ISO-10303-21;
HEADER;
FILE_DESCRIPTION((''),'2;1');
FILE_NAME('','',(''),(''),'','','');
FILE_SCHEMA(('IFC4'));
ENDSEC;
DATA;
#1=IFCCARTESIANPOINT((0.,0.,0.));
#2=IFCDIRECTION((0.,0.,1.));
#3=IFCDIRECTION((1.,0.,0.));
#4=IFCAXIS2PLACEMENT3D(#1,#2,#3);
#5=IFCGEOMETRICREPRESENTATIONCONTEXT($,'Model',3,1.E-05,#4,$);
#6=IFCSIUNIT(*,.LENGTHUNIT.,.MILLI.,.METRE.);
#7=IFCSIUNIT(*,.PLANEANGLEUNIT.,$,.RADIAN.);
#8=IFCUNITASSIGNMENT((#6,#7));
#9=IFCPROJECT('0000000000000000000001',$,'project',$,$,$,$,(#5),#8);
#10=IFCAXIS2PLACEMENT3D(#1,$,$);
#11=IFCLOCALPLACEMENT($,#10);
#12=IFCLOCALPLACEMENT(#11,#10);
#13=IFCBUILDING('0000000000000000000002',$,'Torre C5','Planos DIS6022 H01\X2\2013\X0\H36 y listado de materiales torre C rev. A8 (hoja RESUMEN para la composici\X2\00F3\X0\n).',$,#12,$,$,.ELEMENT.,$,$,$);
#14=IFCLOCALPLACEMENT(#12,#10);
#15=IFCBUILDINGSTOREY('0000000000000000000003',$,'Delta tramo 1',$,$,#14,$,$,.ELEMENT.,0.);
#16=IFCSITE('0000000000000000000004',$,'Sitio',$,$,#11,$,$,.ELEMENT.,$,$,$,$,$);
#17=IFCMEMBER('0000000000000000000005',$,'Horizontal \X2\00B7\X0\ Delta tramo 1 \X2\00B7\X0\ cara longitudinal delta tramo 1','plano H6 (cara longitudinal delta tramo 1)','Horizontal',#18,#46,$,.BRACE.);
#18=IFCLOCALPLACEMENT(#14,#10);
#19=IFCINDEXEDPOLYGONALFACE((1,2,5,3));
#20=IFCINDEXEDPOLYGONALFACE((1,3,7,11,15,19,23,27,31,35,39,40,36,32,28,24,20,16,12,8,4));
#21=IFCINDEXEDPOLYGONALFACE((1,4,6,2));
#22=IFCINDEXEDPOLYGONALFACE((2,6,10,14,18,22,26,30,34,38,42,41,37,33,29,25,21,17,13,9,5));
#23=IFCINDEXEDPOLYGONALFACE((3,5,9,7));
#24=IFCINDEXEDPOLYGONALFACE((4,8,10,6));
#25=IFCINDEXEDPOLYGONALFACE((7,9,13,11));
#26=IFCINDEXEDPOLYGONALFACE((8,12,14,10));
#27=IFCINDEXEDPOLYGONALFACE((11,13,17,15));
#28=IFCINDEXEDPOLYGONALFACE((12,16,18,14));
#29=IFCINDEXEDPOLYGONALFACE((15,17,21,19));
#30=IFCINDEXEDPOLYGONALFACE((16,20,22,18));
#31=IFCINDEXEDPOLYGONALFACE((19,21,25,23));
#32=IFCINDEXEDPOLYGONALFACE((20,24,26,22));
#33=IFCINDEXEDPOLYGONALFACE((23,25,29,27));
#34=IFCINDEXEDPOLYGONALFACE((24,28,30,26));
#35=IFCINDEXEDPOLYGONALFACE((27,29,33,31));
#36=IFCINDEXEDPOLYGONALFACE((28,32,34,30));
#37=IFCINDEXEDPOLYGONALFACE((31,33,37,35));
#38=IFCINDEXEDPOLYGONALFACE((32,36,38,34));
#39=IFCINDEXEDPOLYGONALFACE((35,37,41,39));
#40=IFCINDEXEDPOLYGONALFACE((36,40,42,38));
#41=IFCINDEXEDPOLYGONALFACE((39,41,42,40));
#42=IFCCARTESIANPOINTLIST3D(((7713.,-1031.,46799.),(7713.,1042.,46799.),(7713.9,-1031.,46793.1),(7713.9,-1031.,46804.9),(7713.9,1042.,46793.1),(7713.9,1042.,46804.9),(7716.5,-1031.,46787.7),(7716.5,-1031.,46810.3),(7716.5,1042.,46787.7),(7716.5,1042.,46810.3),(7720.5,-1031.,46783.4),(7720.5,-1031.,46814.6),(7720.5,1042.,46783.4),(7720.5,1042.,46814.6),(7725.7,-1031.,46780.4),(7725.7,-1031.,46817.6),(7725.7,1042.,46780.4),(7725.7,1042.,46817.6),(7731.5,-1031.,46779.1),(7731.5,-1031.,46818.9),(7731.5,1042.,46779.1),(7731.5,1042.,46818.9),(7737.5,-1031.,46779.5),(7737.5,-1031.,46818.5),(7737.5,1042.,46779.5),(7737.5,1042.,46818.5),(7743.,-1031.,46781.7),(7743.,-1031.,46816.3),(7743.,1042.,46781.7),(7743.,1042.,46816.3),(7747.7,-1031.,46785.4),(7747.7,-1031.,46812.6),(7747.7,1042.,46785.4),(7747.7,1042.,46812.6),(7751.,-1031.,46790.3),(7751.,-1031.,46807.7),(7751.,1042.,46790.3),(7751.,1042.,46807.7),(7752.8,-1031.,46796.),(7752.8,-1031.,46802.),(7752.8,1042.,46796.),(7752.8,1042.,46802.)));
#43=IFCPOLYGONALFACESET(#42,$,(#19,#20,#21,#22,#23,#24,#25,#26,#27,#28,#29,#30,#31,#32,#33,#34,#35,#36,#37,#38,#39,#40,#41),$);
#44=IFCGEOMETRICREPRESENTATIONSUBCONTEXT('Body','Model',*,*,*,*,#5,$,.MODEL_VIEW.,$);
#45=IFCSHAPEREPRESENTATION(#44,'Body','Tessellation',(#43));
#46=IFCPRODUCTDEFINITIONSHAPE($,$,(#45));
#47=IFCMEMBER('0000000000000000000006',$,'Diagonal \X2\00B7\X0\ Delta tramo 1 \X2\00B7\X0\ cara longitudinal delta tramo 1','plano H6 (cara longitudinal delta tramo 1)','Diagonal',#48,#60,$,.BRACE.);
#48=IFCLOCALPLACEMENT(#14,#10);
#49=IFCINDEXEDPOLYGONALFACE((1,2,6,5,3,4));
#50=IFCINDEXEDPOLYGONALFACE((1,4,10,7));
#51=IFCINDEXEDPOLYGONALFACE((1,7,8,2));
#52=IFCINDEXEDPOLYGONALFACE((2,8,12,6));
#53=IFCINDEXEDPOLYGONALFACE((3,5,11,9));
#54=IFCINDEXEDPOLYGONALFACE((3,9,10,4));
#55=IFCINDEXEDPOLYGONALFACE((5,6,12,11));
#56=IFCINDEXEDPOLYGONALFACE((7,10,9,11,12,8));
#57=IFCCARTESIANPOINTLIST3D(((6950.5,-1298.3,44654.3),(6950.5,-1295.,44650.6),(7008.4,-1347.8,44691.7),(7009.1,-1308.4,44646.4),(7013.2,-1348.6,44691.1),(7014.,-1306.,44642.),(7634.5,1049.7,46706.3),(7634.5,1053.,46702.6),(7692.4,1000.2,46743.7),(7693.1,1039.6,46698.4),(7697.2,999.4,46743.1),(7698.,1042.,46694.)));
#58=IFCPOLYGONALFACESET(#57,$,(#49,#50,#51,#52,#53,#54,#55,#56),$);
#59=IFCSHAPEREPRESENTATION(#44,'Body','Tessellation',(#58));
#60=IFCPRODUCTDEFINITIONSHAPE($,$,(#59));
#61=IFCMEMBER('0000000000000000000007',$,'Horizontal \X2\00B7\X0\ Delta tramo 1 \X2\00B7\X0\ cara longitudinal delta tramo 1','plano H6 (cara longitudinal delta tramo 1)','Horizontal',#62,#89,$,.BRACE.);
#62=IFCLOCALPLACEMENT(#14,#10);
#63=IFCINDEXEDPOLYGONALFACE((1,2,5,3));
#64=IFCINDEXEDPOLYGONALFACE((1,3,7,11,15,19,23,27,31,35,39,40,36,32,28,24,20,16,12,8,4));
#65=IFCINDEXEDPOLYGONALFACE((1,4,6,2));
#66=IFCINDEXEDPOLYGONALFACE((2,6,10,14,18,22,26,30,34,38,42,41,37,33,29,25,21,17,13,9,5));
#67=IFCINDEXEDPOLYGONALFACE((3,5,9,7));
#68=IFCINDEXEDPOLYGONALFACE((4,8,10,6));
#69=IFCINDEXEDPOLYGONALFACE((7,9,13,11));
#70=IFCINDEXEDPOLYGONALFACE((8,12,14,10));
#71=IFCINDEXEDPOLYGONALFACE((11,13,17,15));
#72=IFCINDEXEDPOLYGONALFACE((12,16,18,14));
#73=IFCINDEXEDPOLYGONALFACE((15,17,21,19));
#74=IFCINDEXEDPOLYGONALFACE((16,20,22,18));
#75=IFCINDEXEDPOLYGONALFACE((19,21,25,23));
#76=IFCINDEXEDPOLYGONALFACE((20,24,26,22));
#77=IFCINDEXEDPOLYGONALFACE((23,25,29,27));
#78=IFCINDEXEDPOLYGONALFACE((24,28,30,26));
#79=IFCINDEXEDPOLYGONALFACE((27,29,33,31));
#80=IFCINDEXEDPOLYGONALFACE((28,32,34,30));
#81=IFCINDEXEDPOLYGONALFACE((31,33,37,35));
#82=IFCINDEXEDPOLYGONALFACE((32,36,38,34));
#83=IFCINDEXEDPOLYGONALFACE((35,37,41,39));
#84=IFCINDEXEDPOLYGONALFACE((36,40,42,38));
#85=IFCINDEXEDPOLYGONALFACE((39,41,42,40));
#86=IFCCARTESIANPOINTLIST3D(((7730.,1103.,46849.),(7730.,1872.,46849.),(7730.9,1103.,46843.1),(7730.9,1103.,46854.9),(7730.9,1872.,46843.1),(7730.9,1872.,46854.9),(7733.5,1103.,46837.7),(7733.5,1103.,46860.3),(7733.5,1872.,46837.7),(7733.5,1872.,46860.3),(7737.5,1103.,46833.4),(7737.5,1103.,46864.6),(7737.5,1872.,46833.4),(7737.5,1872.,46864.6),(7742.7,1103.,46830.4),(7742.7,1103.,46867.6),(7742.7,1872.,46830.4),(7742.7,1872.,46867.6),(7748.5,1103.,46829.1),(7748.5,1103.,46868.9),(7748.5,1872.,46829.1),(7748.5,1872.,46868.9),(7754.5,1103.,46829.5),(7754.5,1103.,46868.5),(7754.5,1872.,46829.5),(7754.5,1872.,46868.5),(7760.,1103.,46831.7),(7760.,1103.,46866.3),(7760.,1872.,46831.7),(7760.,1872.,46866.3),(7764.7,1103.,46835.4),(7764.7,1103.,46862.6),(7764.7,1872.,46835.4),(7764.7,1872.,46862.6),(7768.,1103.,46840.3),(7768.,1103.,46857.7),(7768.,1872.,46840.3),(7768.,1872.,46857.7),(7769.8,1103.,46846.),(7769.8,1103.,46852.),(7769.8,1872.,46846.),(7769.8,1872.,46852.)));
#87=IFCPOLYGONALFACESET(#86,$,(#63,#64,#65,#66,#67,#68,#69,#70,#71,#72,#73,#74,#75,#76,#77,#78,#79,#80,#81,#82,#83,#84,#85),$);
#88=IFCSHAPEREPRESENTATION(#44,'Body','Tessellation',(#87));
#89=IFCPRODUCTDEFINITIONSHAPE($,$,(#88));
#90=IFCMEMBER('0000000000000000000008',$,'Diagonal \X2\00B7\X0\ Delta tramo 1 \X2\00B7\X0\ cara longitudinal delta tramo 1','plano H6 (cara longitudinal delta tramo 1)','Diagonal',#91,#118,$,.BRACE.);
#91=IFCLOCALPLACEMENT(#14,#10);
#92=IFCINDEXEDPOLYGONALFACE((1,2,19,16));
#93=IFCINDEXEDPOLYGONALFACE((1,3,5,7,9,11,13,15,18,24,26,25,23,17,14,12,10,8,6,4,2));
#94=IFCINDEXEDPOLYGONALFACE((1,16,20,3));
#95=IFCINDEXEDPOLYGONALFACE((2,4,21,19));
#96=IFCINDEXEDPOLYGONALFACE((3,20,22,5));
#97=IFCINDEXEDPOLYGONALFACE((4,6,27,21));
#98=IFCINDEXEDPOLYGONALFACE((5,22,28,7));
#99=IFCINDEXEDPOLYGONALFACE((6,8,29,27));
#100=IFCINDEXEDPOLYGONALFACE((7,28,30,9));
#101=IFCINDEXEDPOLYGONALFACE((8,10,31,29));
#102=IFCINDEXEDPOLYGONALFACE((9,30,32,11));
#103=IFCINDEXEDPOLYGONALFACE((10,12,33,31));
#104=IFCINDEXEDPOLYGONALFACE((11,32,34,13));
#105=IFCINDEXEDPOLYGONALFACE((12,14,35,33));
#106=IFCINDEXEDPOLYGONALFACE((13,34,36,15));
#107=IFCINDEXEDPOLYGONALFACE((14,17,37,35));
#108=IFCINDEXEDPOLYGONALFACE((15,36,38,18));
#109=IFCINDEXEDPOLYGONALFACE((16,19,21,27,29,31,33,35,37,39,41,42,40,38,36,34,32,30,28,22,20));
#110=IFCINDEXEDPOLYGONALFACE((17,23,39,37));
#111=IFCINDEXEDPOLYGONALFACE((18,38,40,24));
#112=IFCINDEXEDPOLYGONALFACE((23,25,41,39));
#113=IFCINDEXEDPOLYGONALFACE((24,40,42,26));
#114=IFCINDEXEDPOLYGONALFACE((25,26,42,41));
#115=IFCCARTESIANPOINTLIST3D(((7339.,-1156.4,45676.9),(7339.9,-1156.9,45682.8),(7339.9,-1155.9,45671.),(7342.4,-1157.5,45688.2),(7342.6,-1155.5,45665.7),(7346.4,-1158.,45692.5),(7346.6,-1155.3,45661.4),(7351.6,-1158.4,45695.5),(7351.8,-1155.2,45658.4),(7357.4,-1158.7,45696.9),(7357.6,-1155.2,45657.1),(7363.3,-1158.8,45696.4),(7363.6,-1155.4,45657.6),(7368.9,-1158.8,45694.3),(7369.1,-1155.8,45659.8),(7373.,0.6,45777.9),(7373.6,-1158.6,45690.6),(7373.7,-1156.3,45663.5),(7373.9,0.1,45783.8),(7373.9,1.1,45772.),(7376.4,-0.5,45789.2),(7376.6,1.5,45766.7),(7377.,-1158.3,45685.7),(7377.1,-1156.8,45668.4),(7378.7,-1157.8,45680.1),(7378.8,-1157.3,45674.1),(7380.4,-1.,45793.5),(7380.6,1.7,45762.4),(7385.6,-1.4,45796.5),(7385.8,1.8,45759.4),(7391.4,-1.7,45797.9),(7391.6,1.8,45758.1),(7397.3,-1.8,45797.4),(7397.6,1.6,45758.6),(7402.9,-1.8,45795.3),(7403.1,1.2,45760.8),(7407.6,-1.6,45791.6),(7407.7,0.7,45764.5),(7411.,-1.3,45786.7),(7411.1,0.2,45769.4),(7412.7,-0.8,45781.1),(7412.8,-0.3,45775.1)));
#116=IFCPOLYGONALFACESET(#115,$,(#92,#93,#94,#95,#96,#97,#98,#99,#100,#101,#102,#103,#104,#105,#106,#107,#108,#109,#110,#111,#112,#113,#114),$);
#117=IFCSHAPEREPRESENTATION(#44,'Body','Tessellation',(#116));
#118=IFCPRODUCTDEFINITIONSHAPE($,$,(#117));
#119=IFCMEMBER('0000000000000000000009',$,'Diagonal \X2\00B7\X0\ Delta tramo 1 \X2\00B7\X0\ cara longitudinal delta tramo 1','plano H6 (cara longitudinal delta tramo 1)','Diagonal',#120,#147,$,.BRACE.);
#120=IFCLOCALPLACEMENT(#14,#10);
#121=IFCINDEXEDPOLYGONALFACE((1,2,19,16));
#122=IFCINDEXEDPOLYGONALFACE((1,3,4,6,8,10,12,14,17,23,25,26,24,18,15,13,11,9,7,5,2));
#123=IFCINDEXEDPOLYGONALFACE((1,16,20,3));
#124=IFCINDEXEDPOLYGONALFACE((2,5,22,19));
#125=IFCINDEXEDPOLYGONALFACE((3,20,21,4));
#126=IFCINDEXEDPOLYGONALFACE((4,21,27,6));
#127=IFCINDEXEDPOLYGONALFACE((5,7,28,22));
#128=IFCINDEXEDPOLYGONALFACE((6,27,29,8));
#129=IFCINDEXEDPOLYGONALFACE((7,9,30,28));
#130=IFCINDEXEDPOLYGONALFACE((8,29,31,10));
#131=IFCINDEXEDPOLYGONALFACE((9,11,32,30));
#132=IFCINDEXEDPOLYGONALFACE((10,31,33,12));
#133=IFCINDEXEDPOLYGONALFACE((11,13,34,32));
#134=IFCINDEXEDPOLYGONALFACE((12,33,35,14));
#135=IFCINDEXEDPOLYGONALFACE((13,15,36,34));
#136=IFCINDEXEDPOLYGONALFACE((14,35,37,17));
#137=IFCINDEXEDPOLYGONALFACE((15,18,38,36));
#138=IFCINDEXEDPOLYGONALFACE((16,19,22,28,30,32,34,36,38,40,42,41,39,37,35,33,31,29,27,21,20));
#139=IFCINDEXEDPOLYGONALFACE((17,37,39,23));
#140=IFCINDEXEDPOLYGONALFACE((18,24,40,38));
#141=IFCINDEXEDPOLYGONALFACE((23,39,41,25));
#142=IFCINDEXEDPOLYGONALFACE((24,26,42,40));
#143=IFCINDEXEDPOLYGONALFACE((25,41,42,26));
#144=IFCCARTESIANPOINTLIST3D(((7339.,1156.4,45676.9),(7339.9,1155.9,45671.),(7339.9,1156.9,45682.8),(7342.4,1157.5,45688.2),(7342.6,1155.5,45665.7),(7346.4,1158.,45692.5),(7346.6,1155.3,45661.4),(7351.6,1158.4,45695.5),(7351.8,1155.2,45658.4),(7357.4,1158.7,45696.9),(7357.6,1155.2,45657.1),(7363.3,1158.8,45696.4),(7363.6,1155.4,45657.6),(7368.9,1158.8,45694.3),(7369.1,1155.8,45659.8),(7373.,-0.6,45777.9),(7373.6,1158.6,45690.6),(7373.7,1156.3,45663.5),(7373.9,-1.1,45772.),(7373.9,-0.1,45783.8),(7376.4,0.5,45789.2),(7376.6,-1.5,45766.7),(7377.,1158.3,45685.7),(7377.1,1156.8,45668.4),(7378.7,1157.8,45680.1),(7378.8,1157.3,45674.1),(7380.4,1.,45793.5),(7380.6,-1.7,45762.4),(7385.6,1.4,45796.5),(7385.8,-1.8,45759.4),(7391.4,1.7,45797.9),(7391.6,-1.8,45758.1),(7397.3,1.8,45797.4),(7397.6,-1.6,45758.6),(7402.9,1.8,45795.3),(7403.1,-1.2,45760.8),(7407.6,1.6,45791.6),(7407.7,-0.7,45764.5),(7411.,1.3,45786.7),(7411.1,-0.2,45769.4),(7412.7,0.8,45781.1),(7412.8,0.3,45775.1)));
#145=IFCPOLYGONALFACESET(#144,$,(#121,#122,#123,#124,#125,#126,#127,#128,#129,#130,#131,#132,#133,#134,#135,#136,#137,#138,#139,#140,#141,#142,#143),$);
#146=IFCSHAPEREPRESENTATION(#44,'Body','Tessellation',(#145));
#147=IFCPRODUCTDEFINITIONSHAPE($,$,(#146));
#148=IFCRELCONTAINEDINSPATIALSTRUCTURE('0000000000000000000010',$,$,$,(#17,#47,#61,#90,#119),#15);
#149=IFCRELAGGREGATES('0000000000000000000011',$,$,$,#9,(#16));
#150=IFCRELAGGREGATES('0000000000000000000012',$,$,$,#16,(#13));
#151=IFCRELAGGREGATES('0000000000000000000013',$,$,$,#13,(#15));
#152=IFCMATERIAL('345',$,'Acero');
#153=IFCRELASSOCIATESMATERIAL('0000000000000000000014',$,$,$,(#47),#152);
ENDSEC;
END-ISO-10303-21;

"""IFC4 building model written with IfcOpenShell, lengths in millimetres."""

from ifc_helpers import new_model, si_unit, frame, frame_2d, origin, origin_with_axes, place, context, subcontext, project, spatial, circle, l_section, extrude, material, element, save


model = new_model("IFC4")

# Units and contexts
model_context = context("Model", 3, precision=1e-05, world=origin_with_axes())
body_context = subcontext(model_context, "Body", "Model", "MODEL_VIEW")
ifc_project = project(units=[si_unit("LENGTHUNIT", "METRE", prefix="MILLI"), si_unit("PLANEANGLEUNIT", "RADIAN")], contexts=[model_context])

# Site, building, storey
site_placement = place(None, origin())
site = spatial("IfcSite", under=ifc_project, at=site_placement, Name="Sitio", CompositionType="ELEMENT")
building_placement = place(site_placement, origin())
building = spatial("IfcBuilding", under=site, at=building_placement, Name="Torre C5", Description="Planos DIS6022 H01–H36 y listado de materiales torre C rev. A8 (hoja RESUMEN para la composición).", CompositionType="ELEMENT")
storey_placement = place(building_placement, origin())
storey = spatial("IfcBuildingStorey", under=building, at=storey_placement, Name="Delta tramo 1", CompositionType="ELEMENT", Elevation=0.0)

# Members
ifc_material = material(Name="345", Category="Acero")
member_1_placement = place(storey_placement, frame((7733.0, -1031.0, 46799.0), z_axis=(0.0, 1.0, 0.0), x_axis=(-1.0, 0.0, 0.0)))
element("IfcMember", 1, at=member_1_placement, inside=storey, Name="Horizontal · Delta tramo 1 · cara longitudinal delta tramo 1", Description="plano H6 (cara longitudinal delta tramo 1)", ObjectType="Horizontal", PredefinedType="BRACE", context=body_context, shape_type="SweptSolid", body=[
    extrude(circle(Radius=20.0), None, (0.0, 0.0, 1.0), 2073.0),
])
member_2_placement = place(storey_placement, frame((7014.0, -1306.0, 44642.0), z_axis=(0.214256, 0.735488, 0.642769), x_axis=(-0.976707, 0.169249, 0.131906)))
element("IfcMember", 2, at=member_2_placement, inside=storey, material=ifc_material, Name="Diagonal · Delta tramo 1 · cara longitudinal delta tramo 1", Description="plano H6 (cara longitudinal delta tramo 1)", ObjectType="Diagonal", PredefinedType="BRACE", context=body_context, shape_type="SweptSolid", body=[
    extrude(l_section(Depth=65.0, Width=65.0, Thickness=5.0, at=frame_2d((32.5, 32.5))), None, (0.0, 0.0, 1.0), 3192.4),
])
member_3_placement = place(storey_placement, frame((7750.0, 1103.0, 46849.0), z_axis=(0.0, 1.0, 0.0), x_axis=(-1.0, 0.0, 0.0)))
element("IfcMember", 3, at=member_3_placement, inside=storey, Name="Horizontal · Delta tramo 1 · cara longitudinal delta tramo 1", Description="plano H6 (cara longitudinal delta tramo 1)", ObjectType="Horizontal", PredefinedType="BRACE", context=body_context, shape_type="SweptSolid", body=[
    extrude(circle(Radius=20.0), None, (0.0, 0.0, 1.0), 769.0),
])
for number, where, z_axis, x_axis, name in (
    (4, (7359.0, -1157.0, 45677.0), (0.029262, 0.995785, 0.086927), (-0.999549, 0.029743, -0.004237), "Diagonal · Delta tramo 1 · cara longitudinal delta tramo 1"),
    (5, (7359.0, 1157.0, 45677.0), (0.029262, -0.995785, 0.086927), (-0.999549, -0.029743, -0.004237), "Diagonal · Delta tramo 1 · cara longitudinal delta tramo 1"),
):
    element("IfcMember", number, at=place(storey_placement, frame(where, z_axis=z_axis, x_axis=x_axis)), inside=storey, Name=name, Description="plano H6 (cara longitudinal delta tramo 1)", ObjectType="Diagonal", PredefinedType="BRACE", context=body_context, shape_type="SweptSolid", body=[
        extrude(circle(Radius=20.0), None, (0.0, 0.0, 1.0), 1161.9),
    ])

save(model, "model.ifc")
